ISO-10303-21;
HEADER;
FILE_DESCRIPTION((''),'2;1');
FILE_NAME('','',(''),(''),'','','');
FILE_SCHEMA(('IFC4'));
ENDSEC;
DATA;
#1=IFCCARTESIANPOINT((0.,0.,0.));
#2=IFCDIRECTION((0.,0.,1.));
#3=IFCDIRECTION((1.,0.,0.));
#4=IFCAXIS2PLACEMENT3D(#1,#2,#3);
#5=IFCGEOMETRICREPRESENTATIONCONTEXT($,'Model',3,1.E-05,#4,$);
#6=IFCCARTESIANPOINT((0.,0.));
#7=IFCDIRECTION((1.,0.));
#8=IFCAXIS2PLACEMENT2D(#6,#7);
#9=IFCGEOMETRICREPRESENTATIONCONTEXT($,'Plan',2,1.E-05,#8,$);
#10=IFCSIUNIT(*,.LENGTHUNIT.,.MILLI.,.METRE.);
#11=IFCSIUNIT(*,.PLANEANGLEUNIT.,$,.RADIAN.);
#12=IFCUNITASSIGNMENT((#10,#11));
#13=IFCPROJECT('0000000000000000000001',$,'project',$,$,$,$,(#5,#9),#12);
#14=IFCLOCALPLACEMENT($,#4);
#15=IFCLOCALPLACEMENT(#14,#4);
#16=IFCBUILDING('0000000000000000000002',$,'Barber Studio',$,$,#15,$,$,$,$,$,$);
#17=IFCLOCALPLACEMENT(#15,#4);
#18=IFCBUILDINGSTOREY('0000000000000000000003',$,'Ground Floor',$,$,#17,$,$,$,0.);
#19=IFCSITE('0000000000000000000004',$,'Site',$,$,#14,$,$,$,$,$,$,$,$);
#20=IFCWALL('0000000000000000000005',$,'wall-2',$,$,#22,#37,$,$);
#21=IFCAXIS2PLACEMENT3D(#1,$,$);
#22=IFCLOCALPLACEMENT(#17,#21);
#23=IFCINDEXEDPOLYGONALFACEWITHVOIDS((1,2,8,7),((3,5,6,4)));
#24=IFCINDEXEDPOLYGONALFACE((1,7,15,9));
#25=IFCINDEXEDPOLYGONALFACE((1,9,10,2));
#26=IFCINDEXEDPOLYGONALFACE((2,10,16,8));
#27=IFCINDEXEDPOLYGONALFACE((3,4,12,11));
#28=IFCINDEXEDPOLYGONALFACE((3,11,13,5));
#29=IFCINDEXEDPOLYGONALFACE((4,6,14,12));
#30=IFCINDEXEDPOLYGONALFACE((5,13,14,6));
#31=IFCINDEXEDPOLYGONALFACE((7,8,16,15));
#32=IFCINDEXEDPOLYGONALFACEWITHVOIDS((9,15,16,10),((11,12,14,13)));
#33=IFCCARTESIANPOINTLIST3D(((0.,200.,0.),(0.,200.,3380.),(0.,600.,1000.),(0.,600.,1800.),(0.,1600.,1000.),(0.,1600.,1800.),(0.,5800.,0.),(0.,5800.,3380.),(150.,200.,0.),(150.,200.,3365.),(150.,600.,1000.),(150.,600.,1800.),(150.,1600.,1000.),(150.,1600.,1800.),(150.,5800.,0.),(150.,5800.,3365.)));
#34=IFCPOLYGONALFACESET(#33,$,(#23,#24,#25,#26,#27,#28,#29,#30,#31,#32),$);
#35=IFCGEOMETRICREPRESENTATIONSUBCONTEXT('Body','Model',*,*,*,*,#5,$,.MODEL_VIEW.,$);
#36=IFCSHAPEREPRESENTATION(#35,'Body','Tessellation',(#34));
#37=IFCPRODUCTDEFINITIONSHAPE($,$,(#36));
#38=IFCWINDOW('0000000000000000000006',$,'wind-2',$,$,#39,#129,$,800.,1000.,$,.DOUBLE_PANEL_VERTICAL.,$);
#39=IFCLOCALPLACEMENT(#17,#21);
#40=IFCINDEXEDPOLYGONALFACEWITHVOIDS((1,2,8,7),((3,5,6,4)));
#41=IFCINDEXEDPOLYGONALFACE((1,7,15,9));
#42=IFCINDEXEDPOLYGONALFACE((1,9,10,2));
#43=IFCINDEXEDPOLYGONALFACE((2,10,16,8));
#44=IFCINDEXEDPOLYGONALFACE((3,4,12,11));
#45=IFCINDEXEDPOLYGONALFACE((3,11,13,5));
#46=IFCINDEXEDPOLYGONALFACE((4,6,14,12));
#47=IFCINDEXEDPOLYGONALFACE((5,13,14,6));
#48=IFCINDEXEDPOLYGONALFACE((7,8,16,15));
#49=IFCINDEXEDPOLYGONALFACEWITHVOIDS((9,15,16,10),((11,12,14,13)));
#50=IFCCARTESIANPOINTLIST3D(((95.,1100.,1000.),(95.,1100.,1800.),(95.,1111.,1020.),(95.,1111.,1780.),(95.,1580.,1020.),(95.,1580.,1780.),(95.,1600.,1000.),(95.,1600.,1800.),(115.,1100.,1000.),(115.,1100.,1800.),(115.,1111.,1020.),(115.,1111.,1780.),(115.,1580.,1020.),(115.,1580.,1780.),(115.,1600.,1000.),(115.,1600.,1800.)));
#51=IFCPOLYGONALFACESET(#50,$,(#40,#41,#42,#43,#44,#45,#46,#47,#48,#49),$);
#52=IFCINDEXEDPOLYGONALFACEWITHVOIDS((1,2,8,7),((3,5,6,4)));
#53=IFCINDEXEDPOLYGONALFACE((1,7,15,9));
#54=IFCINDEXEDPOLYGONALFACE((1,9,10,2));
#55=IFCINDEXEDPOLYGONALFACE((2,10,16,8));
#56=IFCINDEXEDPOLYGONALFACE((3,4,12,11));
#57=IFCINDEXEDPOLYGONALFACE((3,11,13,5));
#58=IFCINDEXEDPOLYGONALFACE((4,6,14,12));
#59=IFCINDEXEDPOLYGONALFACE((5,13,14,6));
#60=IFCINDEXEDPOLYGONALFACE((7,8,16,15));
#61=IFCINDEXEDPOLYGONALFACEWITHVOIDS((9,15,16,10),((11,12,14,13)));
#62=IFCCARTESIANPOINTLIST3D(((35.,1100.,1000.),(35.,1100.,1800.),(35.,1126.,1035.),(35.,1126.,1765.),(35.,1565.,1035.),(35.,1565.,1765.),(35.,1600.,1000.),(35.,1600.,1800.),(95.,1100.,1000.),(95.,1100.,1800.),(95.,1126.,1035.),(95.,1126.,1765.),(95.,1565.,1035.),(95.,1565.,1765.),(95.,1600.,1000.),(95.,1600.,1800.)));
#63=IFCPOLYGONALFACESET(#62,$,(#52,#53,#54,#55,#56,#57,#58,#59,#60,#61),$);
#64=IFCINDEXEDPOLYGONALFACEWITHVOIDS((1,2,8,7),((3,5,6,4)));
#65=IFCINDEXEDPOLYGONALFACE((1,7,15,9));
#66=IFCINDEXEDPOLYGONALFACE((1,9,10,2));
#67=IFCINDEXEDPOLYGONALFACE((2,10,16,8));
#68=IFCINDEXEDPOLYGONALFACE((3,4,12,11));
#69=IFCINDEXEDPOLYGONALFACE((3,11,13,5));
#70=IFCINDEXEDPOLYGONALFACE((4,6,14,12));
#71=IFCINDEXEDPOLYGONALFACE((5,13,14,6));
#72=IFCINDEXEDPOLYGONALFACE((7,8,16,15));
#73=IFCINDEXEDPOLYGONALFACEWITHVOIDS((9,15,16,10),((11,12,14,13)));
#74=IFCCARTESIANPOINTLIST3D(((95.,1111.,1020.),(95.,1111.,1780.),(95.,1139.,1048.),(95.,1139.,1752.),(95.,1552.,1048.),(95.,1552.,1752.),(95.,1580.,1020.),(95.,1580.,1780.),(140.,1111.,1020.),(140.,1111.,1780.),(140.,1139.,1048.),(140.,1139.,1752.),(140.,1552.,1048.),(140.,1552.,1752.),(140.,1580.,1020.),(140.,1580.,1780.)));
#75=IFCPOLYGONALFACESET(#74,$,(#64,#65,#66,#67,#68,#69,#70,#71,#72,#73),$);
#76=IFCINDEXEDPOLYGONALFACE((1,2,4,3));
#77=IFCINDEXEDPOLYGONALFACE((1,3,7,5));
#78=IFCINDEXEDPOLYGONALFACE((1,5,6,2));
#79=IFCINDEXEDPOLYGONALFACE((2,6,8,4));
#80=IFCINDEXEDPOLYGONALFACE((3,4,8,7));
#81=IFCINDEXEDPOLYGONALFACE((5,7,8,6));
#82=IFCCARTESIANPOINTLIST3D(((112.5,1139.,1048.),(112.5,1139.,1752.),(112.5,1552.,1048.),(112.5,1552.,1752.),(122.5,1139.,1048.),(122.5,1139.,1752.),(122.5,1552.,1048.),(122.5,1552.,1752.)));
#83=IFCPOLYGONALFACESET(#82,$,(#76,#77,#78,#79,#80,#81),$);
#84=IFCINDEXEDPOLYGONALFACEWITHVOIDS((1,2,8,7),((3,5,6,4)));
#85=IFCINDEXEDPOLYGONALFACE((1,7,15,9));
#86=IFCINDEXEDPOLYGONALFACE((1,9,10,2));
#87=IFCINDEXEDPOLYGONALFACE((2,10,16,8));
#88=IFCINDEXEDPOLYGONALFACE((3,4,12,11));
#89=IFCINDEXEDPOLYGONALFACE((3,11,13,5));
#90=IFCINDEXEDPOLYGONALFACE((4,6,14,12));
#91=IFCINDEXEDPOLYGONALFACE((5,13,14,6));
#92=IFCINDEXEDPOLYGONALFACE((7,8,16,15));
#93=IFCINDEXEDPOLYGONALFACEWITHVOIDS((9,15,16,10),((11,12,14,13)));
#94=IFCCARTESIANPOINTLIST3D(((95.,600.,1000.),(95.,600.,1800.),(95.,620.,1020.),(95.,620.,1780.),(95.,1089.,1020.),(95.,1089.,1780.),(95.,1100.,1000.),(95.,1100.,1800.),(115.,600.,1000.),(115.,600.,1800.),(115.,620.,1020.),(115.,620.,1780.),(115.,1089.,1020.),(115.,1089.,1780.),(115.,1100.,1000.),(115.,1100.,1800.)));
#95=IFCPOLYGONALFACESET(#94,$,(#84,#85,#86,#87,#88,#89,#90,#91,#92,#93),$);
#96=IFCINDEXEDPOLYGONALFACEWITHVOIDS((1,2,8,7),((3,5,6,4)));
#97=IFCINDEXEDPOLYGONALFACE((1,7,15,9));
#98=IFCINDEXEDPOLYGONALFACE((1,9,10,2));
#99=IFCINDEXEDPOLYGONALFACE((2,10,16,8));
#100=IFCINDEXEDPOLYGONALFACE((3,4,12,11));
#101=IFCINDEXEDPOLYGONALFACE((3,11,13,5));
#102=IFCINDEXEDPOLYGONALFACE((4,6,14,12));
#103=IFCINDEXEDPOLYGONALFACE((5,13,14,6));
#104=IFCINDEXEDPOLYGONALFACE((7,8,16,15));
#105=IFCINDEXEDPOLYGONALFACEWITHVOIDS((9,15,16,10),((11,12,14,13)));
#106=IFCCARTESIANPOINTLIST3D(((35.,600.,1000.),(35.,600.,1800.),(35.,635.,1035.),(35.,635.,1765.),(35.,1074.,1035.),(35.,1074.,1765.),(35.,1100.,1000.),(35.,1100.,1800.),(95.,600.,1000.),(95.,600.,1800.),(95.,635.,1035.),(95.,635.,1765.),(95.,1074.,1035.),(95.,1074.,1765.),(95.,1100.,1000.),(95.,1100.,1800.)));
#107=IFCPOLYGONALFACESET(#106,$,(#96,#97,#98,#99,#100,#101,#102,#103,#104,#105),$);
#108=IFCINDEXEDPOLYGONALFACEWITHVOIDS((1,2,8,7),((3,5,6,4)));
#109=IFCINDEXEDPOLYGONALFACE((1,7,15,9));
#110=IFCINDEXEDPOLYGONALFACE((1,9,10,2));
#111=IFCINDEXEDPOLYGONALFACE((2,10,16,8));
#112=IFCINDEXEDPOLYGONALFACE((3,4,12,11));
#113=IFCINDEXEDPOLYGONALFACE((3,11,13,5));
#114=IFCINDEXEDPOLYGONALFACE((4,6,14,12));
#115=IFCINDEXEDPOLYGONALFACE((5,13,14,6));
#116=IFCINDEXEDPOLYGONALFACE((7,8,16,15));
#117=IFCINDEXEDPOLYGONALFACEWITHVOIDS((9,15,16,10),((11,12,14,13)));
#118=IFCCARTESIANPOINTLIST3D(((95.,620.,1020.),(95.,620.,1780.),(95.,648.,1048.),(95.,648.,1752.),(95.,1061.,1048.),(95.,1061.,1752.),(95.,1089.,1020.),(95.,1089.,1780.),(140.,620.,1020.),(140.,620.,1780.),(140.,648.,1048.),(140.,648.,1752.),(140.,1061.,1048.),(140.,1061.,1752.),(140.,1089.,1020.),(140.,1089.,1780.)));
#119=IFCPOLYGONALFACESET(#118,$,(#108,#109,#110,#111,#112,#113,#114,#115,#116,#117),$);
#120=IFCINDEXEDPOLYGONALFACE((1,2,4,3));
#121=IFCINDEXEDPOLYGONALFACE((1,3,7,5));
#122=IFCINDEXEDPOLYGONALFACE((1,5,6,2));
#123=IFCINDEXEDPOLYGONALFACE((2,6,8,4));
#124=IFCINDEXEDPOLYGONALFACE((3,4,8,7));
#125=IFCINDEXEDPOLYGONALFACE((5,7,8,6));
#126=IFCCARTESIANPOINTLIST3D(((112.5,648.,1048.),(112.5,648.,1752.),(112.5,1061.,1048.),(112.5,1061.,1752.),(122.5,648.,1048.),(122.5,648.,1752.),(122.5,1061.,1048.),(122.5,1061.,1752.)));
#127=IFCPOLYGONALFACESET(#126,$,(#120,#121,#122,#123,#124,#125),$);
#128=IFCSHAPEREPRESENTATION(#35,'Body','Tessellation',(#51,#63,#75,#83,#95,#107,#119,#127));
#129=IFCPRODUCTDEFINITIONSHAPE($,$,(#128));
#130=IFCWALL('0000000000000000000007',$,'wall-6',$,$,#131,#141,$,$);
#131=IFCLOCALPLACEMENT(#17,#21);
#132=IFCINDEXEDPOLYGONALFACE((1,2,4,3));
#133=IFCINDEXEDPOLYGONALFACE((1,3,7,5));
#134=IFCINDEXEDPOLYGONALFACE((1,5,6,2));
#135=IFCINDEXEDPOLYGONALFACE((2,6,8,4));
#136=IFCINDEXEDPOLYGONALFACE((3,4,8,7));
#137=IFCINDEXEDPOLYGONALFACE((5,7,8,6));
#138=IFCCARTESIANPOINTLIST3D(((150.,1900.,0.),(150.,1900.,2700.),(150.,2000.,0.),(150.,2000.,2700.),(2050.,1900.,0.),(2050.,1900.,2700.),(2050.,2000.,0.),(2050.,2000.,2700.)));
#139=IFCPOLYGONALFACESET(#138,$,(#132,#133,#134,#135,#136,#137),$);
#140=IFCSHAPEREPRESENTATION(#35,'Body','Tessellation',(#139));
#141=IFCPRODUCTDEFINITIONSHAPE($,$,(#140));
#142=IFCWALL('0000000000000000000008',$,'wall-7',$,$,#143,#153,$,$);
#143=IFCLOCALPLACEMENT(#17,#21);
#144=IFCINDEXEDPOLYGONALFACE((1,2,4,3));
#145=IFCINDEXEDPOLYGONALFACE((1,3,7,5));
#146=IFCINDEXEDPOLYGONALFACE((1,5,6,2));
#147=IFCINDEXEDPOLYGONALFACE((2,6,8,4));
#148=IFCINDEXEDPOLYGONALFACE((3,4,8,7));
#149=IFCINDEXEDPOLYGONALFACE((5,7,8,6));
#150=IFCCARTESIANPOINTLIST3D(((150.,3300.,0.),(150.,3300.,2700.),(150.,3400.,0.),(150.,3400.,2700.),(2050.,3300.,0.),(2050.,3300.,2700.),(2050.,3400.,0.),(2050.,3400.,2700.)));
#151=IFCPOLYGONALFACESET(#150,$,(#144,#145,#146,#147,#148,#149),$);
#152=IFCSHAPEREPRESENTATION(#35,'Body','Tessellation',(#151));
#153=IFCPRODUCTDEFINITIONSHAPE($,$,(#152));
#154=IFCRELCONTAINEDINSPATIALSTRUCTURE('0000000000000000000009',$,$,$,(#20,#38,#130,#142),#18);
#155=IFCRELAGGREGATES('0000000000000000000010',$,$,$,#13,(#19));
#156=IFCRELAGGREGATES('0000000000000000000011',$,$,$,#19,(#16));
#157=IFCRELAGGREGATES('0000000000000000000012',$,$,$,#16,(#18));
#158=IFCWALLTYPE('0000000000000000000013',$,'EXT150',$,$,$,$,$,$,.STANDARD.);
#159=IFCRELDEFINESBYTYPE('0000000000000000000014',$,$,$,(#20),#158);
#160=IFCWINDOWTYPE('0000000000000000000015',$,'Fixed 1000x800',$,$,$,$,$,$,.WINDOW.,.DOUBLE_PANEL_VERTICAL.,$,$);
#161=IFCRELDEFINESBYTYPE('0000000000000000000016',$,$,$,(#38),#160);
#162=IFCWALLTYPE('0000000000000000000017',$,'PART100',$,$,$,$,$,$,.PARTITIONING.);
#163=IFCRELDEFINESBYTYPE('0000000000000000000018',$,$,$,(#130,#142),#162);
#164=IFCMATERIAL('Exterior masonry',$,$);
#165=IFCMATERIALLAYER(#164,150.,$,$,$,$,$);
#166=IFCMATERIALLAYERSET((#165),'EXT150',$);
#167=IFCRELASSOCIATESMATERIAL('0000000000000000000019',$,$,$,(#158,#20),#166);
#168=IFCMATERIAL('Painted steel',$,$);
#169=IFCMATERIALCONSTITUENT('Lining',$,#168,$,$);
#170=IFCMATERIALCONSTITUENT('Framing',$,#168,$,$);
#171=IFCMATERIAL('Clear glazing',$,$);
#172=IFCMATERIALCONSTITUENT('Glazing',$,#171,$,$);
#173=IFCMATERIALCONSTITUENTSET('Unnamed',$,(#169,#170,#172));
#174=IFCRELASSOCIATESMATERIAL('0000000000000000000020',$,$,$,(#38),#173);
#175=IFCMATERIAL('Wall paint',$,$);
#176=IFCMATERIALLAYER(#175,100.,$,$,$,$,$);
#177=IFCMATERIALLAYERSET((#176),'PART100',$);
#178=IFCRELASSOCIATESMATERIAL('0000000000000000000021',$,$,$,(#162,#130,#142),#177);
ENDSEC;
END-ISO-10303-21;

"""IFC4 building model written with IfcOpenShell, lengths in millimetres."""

from ifc_helpers import new_model, entity, si_unit, frame, origin_with_axes, origin_2d_with_axis, place, context, subcontext, project, spatial, line, indexed_curve, outline, extrude, clip, halfspace, shape, material, layer, layer_set, layer_usage, constituent, constituent_set, type_object, element, fill, save


model = new_model("IFC4")

# Units and contexts
model_context = context("Model", 3, precision=1e-05, world=origin_with_axes())
plan_context = context("Plan", 2, precision=1e-05, world=origin_2d_with_axis())
body_context_1 = subcontext(model_context, "Body", "Model", "MODEL_VIEW")
body_context_2 = subcontext(plan_context, "Body", "Plan", "PLAN_VIEW")
ifc_project = project(units=[si_unit("LENGTHUNIT", "METRE", prefix="MILLI"), si_unit("PLANEANGLEUNIT", "RADIAN")], contexts=[model_context, plan_context])

# Site, building, storey
site_placement = place(None, origin_with_axes())
site = spatial("IfcSite", under=ifc_project, at=site_placement, Name="Site")
building_placement = place(site_placement, origin_with_axes())
building = spatial("IfcBuilding", under=site, at=building_placement, Name="Barber Studio")
storey_placement = place(building_placement, origin_with_axes())
storey = spatial("IfcBuildingStorey", under=building, at=storey_placement, Name="Ground Floor", Elevation=0.0)

# Shared definitions
ifc_material_1 = material(Name="Painted steel")

# Shared definitions
ifc_material_2 = material(Name="Exterior masonry")
ifc_layer_1 = layer(ifc_material_2, 150.0)
ifc_layer_set_1 = layer_set([ifc_layer_1], Name="EXT150")
wall_type_1 = type_object("IfcWallType", Name="EXT150", PredefinedType="STANDARD", material=ifc_layer_set_1)
ifc_material_3 = material(Name="Clear glazing")

# Wall, opening, window
ifc_layer_usage_1 = layer_usage(ifc_layer_set_1, "AXIS2", "POSITIVE", 0.0)
wall_1_placement = place(storey_placement, frame((0.0, 5800.0, 0.0), z_axis=(0.0, 0.0, 1.0), x_axis=(0.0, -1.0, 0.0)))
wall_1 = element("IfcWall", 1, at=wall_1_placement, inside=storey, type_object=wall_type_1, material=ifc_layer_usage_1, Name="wall-2", context=body_context_1, shape_type="Clipping", body=[
    clip(extrude(outline(indexed_curve([(0.0, 0.0), (0.0, 150.0), (5600.0, 150.0), (5600.0, 0.0), (0.0, 0.0)], self_intersect=False)), origin_with_axes(), (0.0, 0.0, 1.0), 3600.0), halfspace(frame((0.0, 0.0, 3380.0), z_axis=(0.0, 0.1, 1.0), x_axis=(1.0, 0.0, 0.0)), False)),
])
opening_1_placement = place(wall_1_placement, frame((4200.0, 0.0, 1000.0), z_axis=(0.0, 0.0, 1.0), x_axis=(1.0, 0.0, 0.0)))
opening_1 = element("IfcOpeningElement", 2, at=opening_1_placement, cuts=wall_1, PredefinedType="OPENING", context=body_context_1, shape_type="SweptSolid", body=[
    extrude(outline(indexed_curve([(0.0, 0.0), (1000.0, 0.0), (1000.0, 180.0), (0.0, 180.0)], segments=[line(1, 2, 3, 4, 1)])), frame((0.0, -15.0, 0.0), z_axis=(0.0, 0.0, 1.0), x_axis=(1.0, 0.0, 0.0)), (0.0, 0.0, 1.0), 800.0),
])
ifc_constituent_1 = constituent(ifc_material_1, Name="Lining")
ifc_constituent_2 = constituent(ifc_material_1, Name="Framing")
ifc_constituent_3 = constituent(ifc_material_3, Name="Glazing")
ifc_constituent_set_1 = constituent_set(constituents=[ifc_constituent_1, ifc_constituent_2, ifc_constituent_3], Name="Unnamed")
window_type_1 = type_object("IfcWindowType", Name="Fixed 1000x800", PartitioningType="DOUBLE_PANEL_VERTICAL", PredefinedType="WINDOW")
window_1_placement = place(storey_placement, frame((0.0, 1600.0, 1000.0), z_axis=(0.0, 0.0, 1.0), x_axis=(0.0, -1.0, 0.0)))
window_1 = element("IfcWindow", 3, at=window_1_placement, inside=storey, type_object=window_type_1, material=ifc_constituent_set_1, Name="wind-2", OverallHeight=800.0, OverallWidth=1000.0, PartitioningType="DOUBLE_PANEL_VERTICAL", shapes=[
    shape(body_context_1, "Body", "SweptSolid", [extrude(outline(indexed_curve([(0.0, 0.0), (500.0, 0.0), (500.0, 800.0), (0.0, 800.0)], segments=[line(1, 2, 3, 4, 1)]), holes=[indexed_curve([(20.0, 20.0), (489.0, 20.0), (489.0, 780.0), (20.0, 780.0)], segments=[line(1, 2, 3, 4, 1)])]), frame((0.0, 95.0, 0.0), z_axis=(0.0, -1.0, 0.0), x_axis=(1.0, 0.0, 0.0)), (0.0, 0.0, -1.0), 20.0), extrude(outline(indexed_curve([(0.0, 0.0), (500.0, 0.0), (500.0, 800.0), (0.0, 800.0)], segments=[line(1, 2, 3, 4, 1)]), holes=[indexed_curve([(35.0, 35.0), (474.0, 35.0), (474.0, 765.0), (35.0, 765.0)], segments=[line(1, 2, 3, 4, 1)])]), frame((0.0, 35.0, 0.0), z_axis=(0.0, -1.0, 0.0), x_axis=(1.0, 0.0, 0.0)), (0.0, 0.0, -1.0), 60.0), extrude(outline(indexed_curve([(0.0, 0.0), (469.0, 0.0), (469.0, 760.0), (0.0, 760.0)], segments=[line(1, 2, 3, 4, 1)]), holes=[indexed_curve([(28.0, 28.0), (441.0, 28.0), (441.0, 732.0), (28.0, 732.0)], segments=[line(1, 2, 3, 4, 1)])]), frame((20.0, 95.0, 20.0), z_axis=(0.0, -1.0, 0.0), x_axis=(1.0, 0.0, 0.0)), (0.0, 0.0, -1.0), 45.0), extrude(outline(indexed_curve([(28.0, 28.0), (441.0, 28.0), (441.0, 732.0), (28.0, 732.0)], segments=[line(1, 2, 3, 4, 1)])), frame((20.0, 112.5, 20.0), z_axis=(0.0, -1.0, 0.0), x_axis=(1.0, 0.0, 0.0)), (0.0, 0.0, -1.0), 10.0), extrude(outline(indexed_curve([(0.0, 0.0), (500.0, 0.0), (500.0, 800.0), (0.0, 800.0)], segments=[line(1, 2, 3, 4, 1)]), holes=[indexed_curve([(11.0, 20.0), (480.0, 20.0), (480.0, 780.0), (11.0, 780.0)], segments=[line(1, 2, 3, 4, 1)])]), frame((500.0, 95.0, 0.0), z_axis=(0.0, -1.0, 0.0), x_axis=(1.0, 0.0, 0.0)), (0.0, 0.0, -1.0), 20.0), extrude(outline(indexed_curve([(0.0, 0.0), (500.0, 0.0), (500.0, 800.0), (0.0, 800.0)], segments=[line(1, 2, 3, 4, 1)]), holes=[indexed_curve([(26.0, 35.0), (465.0, 35.0), (465.0, 765.0), (26.0, 765.0)], segments=[line(1, 2, 3, 4, 1)])]), frame((500.0, 35.0, 0.0), z_axis=(0.0, -1.0, 0.0), x_axis=(1.0, 0.0, 0.0)), (0.0, 0.0, -1.0), 60.0), extrude(outline(indexed_curve([(0.0, 0.0), (469.0, 0.0), (469.0, 760.0), (0.0, 760.0)], segments=[line(1, 2, 3, 4, 1)]), holes=[indexed_curve([(28.0, 28.0), (441.0, 28.0), (441.0, 732.0), (28.0, 732.0)], segments=[line(1, 2, 3, 4, 1)])]), frame((511.0, 95.0, 20.0), z_axis=(0.0, -1.0, 0.0), x_axis=(1.0, 0.0, 0.0)), (0.0, 0.0, -1.0), 45.0), extrude(outline(indexed_curve([(28.0, 28.0), (441.0, 28.0), (441.0, 732.0), (28.0, 732.0)], segments=[line(1, 2, 3, 4, 1)])), frame((511.0, 112.5, 20.0), z_axis=(0.0, -1.0, 0.0), x_axis=(1.0, 0.0, 0.0)), (0.0, 0.0, -1.0), 10.0)]),
    shape(body_context_2, "Body", "Curve2D", [entity("IfcIndexedPolyCurve", entity("IfcCartesianPointList2D", [[35.0, 35.0], [474.0, 35.0]])), entity("IfcIndexedPolyCurve", entity("IfcCartesianPointList2D", [[0.0, 115.0], [20.0, 115.0], [20.0, 95.0], [35.0, 95.0], [35.0, 35.0], [0.0, 35.0]]), [entity("IfcLineIndex", [1, 2, 3, 4, 5, 6, 1])]), entity("IfcIndexedPolyCurve", entity("IfcCartesianPointList2D", [[500.0, 115.0], [489.0, 115.0], [489.0, 95.0], [474.0, 95.0], [474.0, 35.0], [500.0, 35.0]])), entity("IfcIndexedPolyCurve", entity("IfcCartesianPointList2D", [[20.0, 95.0], [48.0, 95.0], [48.0, 140.0], [20.0, 140.0]]), [entity("IfcLineIndex", [1, 2, 3, 4, 1])]), entity("IfcIndexedPolyCurve", entity("IfcCartesianPointList2D", [[489.0, 95.0], [461.0, 95.0], [461.0, 140.0], [489.0, 140.0]]), [entity("IfcLineIndex", [1, 2, 3, 4, 1])]), entity("IfcIndexedPolyCurve", entity("IfcCartesianPointList2D", [[48.0, 95.0], [461.0, 95.0]])), entity("IfcIndexedPolyCurve", entity("IfcCartesianPointList2D", [[48.0, 140.0], [461.0, 140.0]])), entity("IfcIndexedPolyCurve", entity("IfcCartesianPointList2D", [[48.0, 117.5], [461.0, 117.5]])), entity("IfcIndexedPolyCurve", entity("IfcCartesianPointList2D", [[526.0, 35.0], [965.0, 35.0]])), entity("IfcIndexedPolyCurve", entity("IfcCartesianPointList2D", [[500.0, 115.0], [511.0, 115.0], [511.0, 95.0], [526.0, 95.0], [526.0, 35.0], [500.0, 35.0]])), entity("IfcIndexedPolyCurve", entity("IfcCartesianPointList2D", [[1000.0, 115.0], [980.0, 115.0], [980.0, 95.0], [965.0, 95.0], [965.0, 35.0], [1000.0, 35.0]]), [entity("IfcLineIndex", [1, 2, 3, 4, 5, 6, 1])]), entity("IfcIndexedPolyCurve", entity("IfcCartesianPointList2D", [[511.0, 95.0], [539.0, 95.0], [539.0, 140.0], [511.0, 140.0]]), [entity("IfcLineIndex", [1, 2, 3, 4, 1])]), entity("IfcIndexedPolyCurve", entity("IfcCartesianPointList2D", [[980.0, 95.0], [952.0, 95.0], [952.0, 140.0], [980.0, 140.0]]), [entity("IfcLineIndex", [1, 2, 3, 4, 1])]), entity("IfcIndexedPolyCurve", entity("IfcCartesianPointList2D", [[539.0, 95.0], [952.0, 95.0]])), entity("IfcIndexedPolyCurve", entity("IfcCartesianPointList2D", [[539.0, 140.0], [952.0, 140.0]])), entity("IfcIndexedPolyCurve", entity("IfcCartesianPointList2D", [[539.0, 117.5], [952.0, 117.5]]))]),
])
fill(opening_1, window_1)

# Walls
ifc_material_4 = material(Name="Wall paint")
ifc_layer_2 = layer(ifc_material_4, 100.0)
ifc_layer_set_2 = layer_set([ifc_layer_2], Name="PART100")
ifc_layer_usage_2 = layer_usage(ifc_layer_set_2, "AXIS2", "POSITIVE", 0.0)
wall_type_2 = type_object("IfcWallType", Name="PART100", PredefinedType="PARTITIONING", material=ifc_layer_set_2)
wall_2_placement = place(storey_placement, frame((150.0, 1900.0, 0.0), z_axis=(0.0, 0.0, 1.0), x_axis=(1.0, 0.0, 0.0)))
element("IfcWall", 4, at=wall_2_placement, inside=storey, type_object=wall_type_2, material=ifc_layer_usage_2, Name="wall-6", context=body_context_1, shape_type="SweptSolid", body=[
    extrude(outline(indexed_curve([(0.0, 0.0), (0.0, 100.0), (1900.0, 100.0), (1900.0, 0.0), (0.0, 0.0)], self_intersect=False)), origin_with_axes(), (0.0, 0.0, 1.0), 2700.0),
])
ifc_layer_usage_3 = layer_usage(ifc_layer_set_2, "AXIS2", "POSITIVE", 0.0)
wall_3_placement = place(storey_placement, frame((150.0, 3300.0, 0.0), z_axis=(0.0, 0.0, 1.0), x_axis=(1.0, 0.0, 0.0)))
element("IfcWall", 5, at=wall_3_placement, inside=storey, type_object=wall_type_2, material=ifc_layer_usage_3, Name="wall-7", context=body_context_1, shape_type="SweptSolid", body=[
    extrude(outline(indexed_curve([(0.0, 0.0), (0.0, 100.0), (1900.0, 100.0), (1900.0, 0.0), (0.0, 0.0)], self_intersect=False)), origin_with_axes(), (0.0, 0.0, 1.0), 2700.0),
])

save(model, "model.ifc")
